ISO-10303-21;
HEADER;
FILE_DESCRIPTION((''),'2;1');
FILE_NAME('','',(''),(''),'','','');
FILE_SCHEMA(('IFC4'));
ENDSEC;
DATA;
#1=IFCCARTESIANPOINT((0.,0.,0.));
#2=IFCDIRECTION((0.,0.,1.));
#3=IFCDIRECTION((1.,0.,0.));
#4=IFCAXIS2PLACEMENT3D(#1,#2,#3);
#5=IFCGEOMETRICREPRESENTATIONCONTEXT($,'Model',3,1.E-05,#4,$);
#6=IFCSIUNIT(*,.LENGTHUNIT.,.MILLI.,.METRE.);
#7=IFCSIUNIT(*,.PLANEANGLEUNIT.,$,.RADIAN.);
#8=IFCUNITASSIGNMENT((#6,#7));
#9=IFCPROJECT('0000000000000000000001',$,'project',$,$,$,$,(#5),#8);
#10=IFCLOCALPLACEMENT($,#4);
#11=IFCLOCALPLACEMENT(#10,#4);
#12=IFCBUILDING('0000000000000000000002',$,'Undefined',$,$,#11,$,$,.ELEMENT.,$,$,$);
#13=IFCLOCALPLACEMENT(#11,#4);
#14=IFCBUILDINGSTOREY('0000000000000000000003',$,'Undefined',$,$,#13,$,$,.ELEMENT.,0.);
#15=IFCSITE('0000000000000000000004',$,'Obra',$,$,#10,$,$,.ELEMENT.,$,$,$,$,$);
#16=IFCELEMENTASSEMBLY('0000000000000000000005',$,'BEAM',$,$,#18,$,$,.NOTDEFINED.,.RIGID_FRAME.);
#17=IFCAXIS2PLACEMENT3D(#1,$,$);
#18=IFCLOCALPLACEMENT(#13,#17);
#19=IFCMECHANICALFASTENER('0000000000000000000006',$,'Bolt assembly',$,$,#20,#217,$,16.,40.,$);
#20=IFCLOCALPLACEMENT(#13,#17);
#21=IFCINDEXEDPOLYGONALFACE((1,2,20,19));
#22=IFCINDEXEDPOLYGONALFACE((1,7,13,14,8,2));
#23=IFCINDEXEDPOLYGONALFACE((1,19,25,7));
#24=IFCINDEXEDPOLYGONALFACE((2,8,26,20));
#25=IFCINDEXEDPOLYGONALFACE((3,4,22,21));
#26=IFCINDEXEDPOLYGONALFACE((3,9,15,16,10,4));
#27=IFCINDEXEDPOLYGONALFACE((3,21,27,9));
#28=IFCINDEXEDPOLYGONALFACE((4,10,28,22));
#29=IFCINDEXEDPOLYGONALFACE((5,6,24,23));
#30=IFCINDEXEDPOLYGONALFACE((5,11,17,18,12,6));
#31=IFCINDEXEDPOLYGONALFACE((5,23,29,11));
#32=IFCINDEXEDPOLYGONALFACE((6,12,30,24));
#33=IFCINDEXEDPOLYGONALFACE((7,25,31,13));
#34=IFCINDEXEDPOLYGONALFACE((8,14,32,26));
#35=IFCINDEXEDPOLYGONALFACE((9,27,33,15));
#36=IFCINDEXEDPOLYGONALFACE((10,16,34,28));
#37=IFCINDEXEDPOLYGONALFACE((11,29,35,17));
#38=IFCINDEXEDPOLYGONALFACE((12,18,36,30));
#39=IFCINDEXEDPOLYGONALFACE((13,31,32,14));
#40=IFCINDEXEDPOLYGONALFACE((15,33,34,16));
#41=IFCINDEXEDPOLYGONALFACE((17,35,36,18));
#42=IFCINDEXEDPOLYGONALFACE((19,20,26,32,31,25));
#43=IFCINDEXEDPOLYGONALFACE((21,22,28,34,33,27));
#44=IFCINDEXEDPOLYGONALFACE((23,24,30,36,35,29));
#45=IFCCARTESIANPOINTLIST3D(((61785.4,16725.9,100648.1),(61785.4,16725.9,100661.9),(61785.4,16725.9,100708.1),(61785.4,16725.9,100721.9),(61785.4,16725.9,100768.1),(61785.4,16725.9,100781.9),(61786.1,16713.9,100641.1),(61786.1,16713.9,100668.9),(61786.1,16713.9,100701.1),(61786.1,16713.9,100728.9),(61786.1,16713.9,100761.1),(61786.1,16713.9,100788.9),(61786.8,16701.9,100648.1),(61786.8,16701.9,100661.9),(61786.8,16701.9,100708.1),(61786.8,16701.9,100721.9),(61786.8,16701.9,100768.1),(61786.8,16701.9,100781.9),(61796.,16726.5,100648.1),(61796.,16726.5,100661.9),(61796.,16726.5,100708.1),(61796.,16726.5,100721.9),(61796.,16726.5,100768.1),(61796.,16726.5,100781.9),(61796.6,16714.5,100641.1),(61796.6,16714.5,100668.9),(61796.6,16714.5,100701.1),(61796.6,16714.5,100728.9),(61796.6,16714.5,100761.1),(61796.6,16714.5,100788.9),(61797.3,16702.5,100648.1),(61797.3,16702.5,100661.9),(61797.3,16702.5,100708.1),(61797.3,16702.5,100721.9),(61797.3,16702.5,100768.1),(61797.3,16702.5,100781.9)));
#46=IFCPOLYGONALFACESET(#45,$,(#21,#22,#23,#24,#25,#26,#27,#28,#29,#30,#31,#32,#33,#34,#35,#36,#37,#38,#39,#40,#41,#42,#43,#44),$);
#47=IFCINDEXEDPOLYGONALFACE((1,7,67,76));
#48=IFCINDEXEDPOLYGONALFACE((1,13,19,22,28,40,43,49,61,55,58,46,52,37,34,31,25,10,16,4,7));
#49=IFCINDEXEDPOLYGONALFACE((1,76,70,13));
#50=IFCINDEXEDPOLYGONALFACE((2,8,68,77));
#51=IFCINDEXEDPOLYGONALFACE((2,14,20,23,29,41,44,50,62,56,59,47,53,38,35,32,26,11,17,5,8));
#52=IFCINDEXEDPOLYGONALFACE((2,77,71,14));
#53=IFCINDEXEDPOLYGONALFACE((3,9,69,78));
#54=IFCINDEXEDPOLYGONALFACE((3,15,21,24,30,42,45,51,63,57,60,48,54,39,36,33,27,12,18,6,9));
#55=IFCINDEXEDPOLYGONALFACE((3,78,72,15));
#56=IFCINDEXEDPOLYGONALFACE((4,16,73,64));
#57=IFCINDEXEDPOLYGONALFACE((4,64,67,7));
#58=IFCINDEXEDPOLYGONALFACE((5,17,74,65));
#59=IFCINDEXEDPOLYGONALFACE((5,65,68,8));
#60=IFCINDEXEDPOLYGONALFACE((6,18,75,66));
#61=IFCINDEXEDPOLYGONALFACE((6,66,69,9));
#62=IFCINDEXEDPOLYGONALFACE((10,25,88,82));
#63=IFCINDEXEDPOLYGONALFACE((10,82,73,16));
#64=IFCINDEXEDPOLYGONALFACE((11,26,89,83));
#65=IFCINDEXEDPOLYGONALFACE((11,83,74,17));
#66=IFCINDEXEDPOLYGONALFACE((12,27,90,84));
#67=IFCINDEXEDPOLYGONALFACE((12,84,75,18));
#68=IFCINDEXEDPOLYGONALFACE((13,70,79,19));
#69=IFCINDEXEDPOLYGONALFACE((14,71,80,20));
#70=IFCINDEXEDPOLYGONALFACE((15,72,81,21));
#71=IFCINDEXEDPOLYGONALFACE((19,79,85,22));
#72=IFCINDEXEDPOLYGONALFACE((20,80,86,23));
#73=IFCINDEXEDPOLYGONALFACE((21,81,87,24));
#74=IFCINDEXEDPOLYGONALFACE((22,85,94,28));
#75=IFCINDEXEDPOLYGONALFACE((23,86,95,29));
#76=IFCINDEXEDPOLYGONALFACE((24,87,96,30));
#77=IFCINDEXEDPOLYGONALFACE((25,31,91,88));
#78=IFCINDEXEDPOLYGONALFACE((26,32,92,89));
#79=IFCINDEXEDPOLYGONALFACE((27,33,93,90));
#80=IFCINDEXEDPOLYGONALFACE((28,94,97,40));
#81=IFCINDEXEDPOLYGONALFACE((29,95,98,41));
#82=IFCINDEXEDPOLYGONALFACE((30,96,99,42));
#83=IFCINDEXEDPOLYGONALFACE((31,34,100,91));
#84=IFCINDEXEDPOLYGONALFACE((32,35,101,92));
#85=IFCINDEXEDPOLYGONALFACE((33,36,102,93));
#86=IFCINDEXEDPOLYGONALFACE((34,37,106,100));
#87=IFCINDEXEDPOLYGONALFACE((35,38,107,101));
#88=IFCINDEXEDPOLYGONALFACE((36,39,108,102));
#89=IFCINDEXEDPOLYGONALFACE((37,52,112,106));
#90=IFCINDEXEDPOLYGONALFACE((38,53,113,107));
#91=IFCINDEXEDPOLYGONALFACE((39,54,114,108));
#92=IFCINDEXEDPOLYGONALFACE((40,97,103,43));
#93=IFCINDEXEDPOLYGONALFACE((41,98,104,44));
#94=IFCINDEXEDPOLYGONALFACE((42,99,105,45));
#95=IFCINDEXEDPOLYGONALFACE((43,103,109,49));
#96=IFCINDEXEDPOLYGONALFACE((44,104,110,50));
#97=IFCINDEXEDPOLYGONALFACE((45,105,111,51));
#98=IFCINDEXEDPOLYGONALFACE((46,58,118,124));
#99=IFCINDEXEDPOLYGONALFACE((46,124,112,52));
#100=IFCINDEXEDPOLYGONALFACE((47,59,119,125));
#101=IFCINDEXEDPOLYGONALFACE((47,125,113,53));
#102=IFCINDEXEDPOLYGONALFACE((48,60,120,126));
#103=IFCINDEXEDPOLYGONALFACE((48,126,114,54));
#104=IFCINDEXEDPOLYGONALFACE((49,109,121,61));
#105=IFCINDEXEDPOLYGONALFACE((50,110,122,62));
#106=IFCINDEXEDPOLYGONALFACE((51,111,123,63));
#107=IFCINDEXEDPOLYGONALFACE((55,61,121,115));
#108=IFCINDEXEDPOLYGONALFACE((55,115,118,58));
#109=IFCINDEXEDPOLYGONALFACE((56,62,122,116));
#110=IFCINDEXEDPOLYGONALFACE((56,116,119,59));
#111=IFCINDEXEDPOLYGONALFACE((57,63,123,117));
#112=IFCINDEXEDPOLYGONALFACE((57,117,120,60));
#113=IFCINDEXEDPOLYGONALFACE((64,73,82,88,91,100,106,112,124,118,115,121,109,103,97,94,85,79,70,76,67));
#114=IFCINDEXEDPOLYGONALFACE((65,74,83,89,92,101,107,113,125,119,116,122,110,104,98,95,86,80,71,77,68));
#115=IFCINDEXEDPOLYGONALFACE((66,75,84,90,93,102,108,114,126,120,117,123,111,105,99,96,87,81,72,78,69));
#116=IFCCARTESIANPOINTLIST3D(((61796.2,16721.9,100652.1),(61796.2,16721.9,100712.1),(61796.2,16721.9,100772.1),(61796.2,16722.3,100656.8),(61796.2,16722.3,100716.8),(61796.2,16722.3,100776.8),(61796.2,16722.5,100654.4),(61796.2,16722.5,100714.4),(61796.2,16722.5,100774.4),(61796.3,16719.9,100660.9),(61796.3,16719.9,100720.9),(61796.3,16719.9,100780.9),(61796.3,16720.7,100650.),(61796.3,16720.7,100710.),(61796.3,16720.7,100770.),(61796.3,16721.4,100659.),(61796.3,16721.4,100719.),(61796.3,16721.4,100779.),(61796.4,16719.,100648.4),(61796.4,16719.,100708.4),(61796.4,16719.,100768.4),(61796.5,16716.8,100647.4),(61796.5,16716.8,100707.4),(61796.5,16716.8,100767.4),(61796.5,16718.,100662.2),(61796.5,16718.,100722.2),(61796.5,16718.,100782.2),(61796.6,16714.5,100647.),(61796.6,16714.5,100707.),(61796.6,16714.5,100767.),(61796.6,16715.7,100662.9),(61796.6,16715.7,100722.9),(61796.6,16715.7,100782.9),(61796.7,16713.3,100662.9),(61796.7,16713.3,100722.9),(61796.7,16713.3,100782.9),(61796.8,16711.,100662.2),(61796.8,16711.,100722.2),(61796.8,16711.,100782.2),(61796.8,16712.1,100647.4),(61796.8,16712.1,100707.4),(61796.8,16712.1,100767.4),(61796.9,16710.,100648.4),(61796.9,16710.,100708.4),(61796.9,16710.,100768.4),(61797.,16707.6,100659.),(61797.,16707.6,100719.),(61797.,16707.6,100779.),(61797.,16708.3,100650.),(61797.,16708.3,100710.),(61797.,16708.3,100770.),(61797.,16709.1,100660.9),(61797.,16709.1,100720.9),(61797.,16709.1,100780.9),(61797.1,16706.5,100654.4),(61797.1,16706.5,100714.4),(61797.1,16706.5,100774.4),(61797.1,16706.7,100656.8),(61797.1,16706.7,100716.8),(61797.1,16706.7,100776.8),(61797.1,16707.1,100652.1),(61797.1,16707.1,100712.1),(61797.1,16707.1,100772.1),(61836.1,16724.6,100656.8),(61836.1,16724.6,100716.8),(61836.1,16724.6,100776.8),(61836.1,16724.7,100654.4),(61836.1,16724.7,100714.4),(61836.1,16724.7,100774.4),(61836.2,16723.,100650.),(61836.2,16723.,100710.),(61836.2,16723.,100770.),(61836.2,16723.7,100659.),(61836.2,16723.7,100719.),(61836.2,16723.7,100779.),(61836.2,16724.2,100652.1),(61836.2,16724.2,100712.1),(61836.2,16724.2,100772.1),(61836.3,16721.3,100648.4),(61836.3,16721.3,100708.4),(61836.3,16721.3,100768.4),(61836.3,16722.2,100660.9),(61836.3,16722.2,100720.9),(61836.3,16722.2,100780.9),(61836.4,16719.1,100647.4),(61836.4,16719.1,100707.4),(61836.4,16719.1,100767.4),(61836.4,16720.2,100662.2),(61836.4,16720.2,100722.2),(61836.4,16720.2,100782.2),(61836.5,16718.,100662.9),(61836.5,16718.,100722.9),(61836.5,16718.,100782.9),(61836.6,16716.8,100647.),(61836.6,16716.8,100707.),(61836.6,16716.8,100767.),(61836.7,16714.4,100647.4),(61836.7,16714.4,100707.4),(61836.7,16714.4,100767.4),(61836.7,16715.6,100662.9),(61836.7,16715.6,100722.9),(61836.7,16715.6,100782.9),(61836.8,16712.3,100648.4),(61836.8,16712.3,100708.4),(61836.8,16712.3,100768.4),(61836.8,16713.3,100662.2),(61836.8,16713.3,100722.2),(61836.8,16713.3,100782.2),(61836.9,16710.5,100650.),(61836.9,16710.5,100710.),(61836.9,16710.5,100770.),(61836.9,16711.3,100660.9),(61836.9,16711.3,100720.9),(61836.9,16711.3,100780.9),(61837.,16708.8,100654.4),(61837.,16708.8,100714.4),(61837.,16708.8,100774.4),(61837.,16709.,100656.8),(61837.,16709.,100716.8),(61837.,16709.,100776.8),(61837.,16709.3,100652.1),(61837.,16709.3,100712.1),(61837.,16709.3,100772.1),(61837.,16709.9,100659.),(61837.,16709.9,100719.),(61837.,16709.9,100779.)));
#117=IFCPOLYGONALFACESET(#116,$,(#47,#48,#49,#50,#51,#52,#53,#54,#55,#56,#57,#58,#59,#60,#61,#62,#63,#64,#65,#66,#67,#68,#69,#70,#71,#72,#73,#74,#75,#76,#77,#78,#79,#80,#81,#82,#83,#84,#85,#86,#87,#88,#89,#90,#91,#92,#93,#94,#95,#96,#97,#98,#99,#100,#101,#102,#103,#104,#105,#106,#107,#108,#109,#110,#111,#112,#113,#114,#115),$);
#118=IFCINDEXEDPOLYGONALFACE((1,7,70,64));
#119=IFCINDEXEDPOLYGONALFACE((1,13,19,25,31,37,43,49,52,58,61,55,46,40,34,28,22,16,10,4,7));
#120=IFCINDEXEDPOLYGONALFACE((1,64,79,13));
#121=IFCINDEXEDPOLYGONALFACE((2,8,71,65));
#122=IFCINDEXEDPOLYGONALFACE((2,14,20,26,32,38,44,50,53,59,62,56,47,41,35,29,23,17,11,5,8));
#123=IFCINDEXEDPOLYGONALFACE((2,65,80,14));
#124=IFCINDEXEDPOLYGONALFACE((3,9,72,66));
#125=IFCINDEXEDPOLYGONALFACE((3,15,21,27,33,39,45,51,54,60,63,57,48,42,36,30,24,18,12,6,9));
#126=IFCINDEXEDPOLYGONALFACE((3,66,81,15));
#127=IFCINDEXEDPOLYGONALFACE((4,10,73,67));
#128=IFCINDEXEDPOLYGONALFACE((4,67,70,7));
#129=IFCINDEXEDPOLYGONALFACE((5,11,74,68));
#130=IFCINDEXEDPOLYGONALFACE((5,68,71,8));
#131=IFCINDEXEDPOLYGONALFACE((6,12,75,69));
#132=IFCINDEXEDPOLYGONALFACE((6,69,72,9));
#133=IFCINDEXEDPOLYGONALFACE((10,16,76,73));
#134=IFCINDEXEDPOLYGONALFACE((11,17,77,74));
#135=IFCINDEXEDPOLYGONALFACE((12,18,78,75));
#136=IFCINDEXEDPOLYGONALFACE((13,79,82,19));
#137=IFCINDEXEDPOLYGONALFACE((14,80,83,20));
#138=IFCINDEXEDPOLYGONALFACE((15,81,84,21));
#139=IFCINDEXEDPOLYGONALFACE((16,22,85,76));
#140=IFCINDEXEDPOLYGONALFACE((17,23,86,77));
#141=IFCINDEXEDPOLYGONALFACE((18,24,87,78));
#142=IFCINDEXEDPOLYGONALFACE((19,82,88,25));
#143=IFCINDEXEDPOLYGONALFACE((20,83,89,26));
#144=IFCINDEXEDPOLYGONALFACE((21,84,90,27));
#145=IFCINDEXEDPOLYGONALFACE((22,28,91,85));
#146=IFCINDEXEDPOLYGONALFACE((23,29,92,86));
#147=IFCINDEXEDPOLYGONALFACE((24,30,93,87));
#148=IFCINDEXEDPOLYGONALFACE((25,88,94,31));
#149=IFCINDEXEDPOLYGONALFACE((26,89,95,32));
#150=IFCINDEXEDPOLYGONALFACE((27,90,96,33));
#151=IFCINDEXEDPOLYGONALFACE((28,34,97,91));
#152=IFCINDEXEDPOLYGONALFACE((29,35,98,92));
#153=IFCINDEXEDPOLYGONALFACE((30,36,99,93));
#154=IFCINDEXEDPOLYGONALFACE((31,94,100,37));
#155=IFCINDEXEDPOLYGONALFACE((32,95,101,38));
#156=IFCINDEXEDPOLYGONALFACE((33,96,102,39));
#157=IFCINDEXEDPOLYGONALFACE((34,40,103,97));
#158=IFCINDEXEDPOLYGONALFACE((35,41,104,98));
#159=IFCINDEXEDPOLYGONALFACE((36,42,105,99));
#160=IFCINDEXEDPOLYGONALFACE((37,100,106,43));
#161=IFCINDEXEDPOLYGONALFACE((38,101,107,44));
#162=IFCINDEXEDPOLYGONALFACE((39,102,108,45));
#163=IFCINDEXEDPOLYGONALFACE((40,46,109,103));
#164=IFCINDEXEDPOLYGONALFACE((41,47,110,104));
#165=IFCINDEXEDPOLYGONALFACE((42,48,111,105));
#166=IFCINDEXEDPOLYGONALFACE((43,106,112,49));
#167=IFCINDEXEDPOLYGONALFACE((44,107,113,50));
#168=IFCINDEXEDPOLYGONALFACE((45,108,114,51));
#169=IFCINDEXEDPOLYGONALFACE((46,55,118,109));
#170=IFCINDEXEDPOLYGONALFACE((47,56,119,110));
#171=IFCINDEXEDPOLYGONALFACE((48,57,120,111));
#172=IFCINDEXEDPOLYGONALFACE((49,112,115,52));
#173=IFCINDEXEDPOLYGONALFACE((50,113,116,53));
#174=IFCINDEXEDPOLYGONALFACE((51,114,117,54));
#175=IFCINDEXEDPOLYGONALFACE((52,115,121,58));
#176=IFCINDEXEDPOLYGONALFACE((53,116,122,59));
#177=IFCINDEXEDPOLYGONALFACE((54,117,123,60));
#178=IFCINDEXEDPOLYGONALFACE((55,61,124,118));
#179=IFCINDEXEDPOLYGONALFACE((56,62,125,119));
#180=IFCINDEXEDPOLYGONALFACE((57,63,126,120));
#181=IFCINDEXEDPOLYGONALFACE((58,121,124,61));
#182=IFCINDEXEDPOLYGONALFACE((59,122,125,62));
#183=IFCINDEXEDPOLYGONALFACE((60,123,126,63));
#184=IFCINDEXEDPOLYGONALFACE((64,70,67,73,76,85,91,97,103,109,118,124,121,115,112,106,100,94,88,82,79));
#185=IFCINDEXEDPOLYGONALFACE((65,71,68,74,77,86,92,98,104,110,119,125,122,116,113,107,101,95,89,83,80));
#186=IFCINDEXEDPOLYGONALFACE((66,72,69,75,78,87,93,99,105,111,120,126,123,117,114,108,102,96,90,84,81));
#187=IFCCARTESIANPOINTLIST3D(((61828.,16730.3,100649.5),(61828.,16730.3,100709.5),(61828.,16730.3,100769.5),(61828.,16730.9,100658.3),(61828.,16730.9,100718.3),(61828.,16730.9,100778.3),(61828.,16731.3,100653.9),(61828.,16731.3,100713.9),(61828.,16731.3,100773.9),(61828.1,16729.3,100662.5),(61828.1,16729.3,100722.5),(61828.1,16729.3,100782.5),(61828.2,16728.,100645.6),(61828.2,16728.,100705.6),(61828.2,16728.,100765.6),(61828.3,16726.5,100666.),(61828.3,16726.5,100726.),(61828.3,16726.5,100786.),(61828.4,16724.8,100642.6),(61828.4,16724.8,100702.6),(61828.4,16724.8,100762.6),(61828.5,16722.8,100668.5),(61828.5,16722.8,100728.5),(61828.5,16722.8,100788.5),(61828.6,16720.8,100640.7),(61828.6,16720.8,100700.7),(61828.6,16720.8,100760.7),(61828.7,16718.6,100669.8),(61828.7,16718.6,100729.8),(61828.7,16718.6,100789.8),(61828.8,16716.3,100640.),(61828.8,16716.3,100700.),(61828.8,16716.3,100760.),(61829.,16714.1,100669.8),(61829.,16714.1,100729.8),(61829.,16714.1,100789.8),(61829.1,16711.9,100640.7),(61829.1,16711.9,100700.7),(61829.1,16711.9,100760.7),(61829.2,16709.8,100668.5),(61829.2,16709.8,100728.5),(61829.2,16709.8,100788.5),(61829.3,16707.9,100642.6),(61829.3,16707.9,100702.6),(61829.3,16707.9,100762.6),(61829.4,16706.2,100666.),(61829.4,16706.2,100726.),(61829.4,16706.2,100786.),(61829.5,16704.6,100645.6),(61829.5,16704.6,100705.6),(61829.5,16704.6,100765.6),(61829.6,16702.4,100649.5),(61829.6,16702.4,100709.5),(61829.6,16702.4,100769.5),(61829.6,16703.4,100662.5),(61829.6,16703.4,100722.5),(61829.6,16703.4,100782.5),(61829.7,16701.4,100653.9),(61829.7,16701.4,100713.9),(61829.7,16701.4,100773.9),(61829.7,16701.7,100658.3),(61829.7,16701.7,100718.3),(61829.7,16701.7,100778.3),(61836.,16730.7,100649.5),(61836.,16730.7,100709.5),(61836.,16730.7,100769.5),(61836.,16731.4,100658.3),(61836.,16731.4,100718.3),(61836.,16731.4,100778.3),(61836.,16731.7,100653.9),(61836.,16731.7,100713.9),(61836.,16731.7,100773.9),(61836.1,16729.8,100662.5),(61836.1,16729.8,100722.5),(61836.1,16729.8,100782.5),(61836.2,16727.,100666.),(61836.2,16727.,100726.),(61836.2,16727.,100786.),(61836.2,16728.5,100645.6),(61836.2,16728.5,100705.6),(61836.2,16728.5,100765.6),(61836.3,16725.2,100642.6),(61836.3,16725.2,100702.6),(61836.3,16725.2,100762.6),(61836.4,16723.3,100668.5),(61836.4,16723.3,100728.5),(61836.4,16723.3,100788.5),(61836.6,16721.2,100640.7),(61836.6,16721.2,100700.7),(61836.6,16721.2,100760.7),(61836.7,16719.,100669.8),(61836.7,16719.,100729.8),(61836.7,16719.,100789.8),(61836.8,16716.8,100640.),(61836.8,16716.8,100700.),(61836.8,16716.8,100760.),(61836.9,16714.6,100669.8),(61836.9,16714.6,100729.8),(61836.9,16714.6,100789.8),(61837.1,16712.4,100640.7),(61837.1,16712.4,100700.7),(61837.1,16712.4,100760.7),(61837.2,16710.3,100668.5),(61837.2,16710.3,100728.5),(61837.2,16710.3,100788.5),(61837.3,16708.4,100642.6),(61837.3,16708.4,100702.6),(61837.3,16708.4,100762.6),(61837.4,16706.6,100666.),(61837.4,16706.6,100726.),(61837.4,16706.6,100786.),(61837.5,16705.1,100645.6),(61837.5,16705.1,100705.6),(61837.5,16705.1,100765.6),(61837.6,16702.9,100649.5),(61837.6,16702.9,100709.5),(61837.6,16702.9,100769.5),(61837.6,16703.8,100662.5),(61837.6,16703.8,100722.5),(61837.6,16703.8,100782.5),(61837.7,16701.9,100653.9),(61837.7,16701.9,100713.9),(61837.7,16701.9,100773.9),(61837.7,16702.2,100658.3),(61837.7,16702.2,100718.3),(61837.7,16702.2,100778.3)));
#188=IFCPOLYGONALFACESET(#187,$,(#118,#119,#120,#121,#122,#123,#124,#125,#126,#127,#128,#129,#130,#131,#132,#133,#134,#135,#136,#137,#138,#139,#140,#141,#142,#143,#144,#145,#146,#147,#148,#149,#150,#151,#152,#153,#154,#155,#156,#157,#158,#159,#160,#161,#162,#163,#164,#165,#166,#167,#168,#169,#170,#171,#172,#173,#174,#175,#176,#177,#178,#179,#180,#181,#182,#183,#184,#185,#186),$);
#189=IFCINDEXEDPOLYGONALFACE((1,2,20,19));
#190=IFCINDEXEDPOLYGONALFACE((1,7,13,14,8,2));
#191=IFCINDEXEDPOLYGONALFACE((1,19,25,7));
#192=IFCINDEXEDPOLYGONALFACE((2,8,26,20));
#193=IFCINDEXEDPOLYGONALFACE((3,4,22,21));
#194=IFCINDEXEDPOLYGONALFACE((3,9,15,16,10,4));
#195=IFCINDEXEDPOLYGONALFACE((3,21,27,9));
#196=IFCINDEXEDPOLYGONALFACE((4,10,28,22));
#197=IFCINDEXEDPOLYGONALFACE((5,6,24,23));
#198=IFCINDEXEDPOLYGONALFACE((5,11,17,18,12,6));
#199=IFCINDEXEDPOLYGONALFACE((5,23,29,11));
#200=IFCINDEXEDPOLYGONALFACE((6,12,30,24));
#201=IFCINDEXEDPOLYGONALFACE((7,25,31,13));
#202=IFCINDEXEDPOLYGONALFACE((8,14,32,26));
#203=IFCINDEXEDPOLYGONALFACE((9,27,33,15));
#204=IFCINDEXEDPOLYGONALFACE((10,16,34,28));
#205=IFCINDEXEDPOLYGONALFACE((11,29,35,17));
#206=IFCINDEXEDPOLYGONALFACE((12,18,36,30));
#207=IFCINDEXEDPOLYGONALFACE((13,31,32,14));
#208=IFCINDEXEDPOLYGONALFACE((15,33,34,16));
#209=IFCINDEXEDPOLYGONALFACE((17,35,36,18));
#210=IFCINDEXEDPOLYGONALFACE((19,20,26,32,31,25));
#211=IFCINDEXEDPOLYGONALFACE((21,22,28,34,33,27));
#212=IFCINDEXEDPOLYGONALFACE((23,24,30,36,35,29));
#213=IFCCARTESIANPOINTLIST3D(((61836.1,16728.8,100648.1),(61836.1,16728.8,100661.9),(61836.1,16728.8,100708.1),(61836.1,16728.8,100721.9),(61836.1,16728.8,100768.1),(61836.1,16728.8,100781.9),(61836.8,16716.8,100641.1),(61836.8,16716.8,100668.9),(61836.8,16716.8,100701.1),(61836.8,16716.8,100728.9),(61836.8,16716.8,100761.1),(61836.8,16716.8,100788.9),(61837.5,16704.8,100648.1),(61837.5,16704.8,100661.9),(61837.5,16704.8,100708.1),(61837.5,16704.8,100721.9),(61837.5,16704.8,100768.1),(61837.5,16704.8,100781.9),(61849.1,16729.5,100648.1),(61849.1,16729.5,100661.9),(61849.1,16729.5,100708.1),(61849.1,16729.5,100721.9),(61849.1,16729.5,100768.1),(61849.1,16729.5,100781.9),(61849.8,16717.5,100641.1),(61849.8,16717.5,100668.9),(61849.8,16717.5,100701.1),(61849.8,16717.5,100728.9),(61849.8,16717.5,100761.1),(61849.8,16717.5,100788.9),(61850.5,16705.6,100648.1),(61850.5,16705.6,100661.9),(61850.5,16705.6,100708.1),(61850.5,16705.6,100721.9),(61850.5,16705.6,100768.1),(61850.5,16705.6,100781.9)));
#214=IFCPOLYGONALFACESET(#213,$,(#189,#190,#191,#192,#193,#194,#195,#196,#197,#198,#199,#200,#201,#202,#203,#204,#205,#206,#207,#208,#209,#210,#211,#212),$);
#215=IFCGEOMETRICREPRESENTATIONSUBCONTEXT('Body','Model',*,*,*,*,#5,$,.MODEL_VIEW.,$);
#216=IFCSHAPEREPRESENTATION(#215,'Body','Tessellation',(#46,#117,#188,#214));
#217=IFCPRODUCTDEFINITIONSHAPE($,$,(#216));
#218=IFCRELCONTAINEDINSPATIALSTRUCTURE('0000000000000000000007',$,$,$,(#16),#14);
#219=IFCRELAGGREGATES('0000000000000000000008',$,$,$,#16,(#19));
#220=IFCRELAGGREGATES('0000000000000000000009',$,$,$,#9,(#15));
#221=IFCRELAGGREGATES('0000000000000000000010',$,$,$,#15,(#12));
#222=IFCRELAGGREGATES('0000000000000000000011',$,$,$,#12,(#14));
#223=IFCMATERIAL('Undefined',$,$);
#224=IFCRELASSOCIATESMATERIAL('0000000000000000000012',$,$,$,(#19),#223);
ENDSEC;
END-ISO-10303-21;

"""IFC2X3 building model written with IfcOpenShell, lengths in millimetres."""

from ifc_helpers import new_model, si_unit, frame, origin_with_axes, origin_2d_with_axis, place, context, subcontext, project, spatial, polyline, circle, outline, extrude, source, transform, mapped, material, element, aggregate, save


model = new_model("IFC2X3")

# Units and contexts
model_context = context("Model", 3, precision=1e-05, world=origin_with_axes())
body_context = subcontext(model_context, "Body", "Model", "MODEL_VIEW")
ifc_project = project(units=[si_unit("LENGTHUNIT", "METRE", prefix="MILLI"), si_unit("PLANEANGLEUNIT", "RADIAN")], contexts=[model_context])

# Site, building, storey
site_placement = place(None, origin_with_axes())
site = spatial("IfcSite", under=ifc_project, at=site_placement, Name="Obra", CompositionType="ELEMENT")
building_placement = place(site_placement, origin_with_axes())
building = spatial("IfcBuilding", under=site, at=building_placement, Name="Undefined", CompositionType="ELEMENT")
storey_placement = place(building_placement, origin_with_axes())
storey = spatial("IfcBuildingStorey", under=building, at=storey_placement, Name="Undefined", CompositionType="ELEMENT", Elevation=0.0)

# Shared definitions
ifc_material_1 = material(Name="Undefined")

# Element assembly
assembly_1_placement = place(storey_placement, origin_with_axes())
assembly_1 = element("IfcElementAssembly", 1, at=assembly_1_placement, inside=storey, Name="BEAM", AssemblyPlace="NOTDEFINED", PredefinedType="RIGID_FRAME")

# Mechanical fastener
shared_shape_1 = source(origin_with_axes(), body_context, "Body", "SweptSolid", [
    extrude(outline(polyline([(13.9, 0.0), (6.9, 12.0), (-6.9, 12.0), (-13.9, 0.0), (-6.9, -12.0), (6.9, -12.0), (13.9, 0.0)])), frame((0.0, -45.9, 0.0), z_axis=(0.0, 1.0, 0.0), x_axis=(1.0, 0.0, 0.0)), (0.0, 0.0, 1.0), 10.6),
    extrude(circle(Radius=8.0, at=origin_2d_with_axis()), frame((0.0, -35.3, 0.0), z_axis=(0.0, 1.0, 0.0), x_axis=(1.0, 0.0, 0.0)), (0.0, 0.0, 1.0), 40.0),
    extrude(circle(Radius=15.0, at=origin_2d_with_axis()), frame((0.0, -3.1, 0.0), z_axis=(0.0, 1.0, 0.0), x_axis=(1.0, 0.0, 0.0)), (0.0, 0.0, 1.0), 8.0),
    extrude(outline(polyline([(13.9, 0.0), (6.9, 12.0), (-6.9, 12.0), (-13.9, 0.0), (-6.9, -12.0), (6.9, -12.0), (13.9, 0.0)])), frame((0.0, 4.9, 0.0), z_axis=(0.0, 1.0, 0.0), x_axis=(1.0, 0.0, 0.0)), (0.0, 0.0, 1.0), 13.0),
])
mechanical_fastener_1_placement = place(assembly_1_placement, frame((61829.1, 16766.4, 100835.0), z_axis=(0.057107, -0.998368, 0.0), x_axis=(0.0, 0.0, -1.0)))
mechanical_fastener_1 = element("IfcMechanicalFastener", 2, at=mechanical_fastener_1_placement, material=ifc_material_1, Name="Bolt assembly", NominalDiameter=16.0, NominalLength=40.0, context=body_context, shape_type="MappedRepresentation", body=[
    mapped(shared_shape_1, transform((60.0, 0.0, 50.0))),
    mapped(shared_shape_1, transform((120.0, 0.0, 50.0))),
    mapped(shared_shape_1, transform((180.0, 0.0, 50.0))),
])
aggregate(assembly_1, [mechanical_fastener_1])

save(model, "model.ifc")
